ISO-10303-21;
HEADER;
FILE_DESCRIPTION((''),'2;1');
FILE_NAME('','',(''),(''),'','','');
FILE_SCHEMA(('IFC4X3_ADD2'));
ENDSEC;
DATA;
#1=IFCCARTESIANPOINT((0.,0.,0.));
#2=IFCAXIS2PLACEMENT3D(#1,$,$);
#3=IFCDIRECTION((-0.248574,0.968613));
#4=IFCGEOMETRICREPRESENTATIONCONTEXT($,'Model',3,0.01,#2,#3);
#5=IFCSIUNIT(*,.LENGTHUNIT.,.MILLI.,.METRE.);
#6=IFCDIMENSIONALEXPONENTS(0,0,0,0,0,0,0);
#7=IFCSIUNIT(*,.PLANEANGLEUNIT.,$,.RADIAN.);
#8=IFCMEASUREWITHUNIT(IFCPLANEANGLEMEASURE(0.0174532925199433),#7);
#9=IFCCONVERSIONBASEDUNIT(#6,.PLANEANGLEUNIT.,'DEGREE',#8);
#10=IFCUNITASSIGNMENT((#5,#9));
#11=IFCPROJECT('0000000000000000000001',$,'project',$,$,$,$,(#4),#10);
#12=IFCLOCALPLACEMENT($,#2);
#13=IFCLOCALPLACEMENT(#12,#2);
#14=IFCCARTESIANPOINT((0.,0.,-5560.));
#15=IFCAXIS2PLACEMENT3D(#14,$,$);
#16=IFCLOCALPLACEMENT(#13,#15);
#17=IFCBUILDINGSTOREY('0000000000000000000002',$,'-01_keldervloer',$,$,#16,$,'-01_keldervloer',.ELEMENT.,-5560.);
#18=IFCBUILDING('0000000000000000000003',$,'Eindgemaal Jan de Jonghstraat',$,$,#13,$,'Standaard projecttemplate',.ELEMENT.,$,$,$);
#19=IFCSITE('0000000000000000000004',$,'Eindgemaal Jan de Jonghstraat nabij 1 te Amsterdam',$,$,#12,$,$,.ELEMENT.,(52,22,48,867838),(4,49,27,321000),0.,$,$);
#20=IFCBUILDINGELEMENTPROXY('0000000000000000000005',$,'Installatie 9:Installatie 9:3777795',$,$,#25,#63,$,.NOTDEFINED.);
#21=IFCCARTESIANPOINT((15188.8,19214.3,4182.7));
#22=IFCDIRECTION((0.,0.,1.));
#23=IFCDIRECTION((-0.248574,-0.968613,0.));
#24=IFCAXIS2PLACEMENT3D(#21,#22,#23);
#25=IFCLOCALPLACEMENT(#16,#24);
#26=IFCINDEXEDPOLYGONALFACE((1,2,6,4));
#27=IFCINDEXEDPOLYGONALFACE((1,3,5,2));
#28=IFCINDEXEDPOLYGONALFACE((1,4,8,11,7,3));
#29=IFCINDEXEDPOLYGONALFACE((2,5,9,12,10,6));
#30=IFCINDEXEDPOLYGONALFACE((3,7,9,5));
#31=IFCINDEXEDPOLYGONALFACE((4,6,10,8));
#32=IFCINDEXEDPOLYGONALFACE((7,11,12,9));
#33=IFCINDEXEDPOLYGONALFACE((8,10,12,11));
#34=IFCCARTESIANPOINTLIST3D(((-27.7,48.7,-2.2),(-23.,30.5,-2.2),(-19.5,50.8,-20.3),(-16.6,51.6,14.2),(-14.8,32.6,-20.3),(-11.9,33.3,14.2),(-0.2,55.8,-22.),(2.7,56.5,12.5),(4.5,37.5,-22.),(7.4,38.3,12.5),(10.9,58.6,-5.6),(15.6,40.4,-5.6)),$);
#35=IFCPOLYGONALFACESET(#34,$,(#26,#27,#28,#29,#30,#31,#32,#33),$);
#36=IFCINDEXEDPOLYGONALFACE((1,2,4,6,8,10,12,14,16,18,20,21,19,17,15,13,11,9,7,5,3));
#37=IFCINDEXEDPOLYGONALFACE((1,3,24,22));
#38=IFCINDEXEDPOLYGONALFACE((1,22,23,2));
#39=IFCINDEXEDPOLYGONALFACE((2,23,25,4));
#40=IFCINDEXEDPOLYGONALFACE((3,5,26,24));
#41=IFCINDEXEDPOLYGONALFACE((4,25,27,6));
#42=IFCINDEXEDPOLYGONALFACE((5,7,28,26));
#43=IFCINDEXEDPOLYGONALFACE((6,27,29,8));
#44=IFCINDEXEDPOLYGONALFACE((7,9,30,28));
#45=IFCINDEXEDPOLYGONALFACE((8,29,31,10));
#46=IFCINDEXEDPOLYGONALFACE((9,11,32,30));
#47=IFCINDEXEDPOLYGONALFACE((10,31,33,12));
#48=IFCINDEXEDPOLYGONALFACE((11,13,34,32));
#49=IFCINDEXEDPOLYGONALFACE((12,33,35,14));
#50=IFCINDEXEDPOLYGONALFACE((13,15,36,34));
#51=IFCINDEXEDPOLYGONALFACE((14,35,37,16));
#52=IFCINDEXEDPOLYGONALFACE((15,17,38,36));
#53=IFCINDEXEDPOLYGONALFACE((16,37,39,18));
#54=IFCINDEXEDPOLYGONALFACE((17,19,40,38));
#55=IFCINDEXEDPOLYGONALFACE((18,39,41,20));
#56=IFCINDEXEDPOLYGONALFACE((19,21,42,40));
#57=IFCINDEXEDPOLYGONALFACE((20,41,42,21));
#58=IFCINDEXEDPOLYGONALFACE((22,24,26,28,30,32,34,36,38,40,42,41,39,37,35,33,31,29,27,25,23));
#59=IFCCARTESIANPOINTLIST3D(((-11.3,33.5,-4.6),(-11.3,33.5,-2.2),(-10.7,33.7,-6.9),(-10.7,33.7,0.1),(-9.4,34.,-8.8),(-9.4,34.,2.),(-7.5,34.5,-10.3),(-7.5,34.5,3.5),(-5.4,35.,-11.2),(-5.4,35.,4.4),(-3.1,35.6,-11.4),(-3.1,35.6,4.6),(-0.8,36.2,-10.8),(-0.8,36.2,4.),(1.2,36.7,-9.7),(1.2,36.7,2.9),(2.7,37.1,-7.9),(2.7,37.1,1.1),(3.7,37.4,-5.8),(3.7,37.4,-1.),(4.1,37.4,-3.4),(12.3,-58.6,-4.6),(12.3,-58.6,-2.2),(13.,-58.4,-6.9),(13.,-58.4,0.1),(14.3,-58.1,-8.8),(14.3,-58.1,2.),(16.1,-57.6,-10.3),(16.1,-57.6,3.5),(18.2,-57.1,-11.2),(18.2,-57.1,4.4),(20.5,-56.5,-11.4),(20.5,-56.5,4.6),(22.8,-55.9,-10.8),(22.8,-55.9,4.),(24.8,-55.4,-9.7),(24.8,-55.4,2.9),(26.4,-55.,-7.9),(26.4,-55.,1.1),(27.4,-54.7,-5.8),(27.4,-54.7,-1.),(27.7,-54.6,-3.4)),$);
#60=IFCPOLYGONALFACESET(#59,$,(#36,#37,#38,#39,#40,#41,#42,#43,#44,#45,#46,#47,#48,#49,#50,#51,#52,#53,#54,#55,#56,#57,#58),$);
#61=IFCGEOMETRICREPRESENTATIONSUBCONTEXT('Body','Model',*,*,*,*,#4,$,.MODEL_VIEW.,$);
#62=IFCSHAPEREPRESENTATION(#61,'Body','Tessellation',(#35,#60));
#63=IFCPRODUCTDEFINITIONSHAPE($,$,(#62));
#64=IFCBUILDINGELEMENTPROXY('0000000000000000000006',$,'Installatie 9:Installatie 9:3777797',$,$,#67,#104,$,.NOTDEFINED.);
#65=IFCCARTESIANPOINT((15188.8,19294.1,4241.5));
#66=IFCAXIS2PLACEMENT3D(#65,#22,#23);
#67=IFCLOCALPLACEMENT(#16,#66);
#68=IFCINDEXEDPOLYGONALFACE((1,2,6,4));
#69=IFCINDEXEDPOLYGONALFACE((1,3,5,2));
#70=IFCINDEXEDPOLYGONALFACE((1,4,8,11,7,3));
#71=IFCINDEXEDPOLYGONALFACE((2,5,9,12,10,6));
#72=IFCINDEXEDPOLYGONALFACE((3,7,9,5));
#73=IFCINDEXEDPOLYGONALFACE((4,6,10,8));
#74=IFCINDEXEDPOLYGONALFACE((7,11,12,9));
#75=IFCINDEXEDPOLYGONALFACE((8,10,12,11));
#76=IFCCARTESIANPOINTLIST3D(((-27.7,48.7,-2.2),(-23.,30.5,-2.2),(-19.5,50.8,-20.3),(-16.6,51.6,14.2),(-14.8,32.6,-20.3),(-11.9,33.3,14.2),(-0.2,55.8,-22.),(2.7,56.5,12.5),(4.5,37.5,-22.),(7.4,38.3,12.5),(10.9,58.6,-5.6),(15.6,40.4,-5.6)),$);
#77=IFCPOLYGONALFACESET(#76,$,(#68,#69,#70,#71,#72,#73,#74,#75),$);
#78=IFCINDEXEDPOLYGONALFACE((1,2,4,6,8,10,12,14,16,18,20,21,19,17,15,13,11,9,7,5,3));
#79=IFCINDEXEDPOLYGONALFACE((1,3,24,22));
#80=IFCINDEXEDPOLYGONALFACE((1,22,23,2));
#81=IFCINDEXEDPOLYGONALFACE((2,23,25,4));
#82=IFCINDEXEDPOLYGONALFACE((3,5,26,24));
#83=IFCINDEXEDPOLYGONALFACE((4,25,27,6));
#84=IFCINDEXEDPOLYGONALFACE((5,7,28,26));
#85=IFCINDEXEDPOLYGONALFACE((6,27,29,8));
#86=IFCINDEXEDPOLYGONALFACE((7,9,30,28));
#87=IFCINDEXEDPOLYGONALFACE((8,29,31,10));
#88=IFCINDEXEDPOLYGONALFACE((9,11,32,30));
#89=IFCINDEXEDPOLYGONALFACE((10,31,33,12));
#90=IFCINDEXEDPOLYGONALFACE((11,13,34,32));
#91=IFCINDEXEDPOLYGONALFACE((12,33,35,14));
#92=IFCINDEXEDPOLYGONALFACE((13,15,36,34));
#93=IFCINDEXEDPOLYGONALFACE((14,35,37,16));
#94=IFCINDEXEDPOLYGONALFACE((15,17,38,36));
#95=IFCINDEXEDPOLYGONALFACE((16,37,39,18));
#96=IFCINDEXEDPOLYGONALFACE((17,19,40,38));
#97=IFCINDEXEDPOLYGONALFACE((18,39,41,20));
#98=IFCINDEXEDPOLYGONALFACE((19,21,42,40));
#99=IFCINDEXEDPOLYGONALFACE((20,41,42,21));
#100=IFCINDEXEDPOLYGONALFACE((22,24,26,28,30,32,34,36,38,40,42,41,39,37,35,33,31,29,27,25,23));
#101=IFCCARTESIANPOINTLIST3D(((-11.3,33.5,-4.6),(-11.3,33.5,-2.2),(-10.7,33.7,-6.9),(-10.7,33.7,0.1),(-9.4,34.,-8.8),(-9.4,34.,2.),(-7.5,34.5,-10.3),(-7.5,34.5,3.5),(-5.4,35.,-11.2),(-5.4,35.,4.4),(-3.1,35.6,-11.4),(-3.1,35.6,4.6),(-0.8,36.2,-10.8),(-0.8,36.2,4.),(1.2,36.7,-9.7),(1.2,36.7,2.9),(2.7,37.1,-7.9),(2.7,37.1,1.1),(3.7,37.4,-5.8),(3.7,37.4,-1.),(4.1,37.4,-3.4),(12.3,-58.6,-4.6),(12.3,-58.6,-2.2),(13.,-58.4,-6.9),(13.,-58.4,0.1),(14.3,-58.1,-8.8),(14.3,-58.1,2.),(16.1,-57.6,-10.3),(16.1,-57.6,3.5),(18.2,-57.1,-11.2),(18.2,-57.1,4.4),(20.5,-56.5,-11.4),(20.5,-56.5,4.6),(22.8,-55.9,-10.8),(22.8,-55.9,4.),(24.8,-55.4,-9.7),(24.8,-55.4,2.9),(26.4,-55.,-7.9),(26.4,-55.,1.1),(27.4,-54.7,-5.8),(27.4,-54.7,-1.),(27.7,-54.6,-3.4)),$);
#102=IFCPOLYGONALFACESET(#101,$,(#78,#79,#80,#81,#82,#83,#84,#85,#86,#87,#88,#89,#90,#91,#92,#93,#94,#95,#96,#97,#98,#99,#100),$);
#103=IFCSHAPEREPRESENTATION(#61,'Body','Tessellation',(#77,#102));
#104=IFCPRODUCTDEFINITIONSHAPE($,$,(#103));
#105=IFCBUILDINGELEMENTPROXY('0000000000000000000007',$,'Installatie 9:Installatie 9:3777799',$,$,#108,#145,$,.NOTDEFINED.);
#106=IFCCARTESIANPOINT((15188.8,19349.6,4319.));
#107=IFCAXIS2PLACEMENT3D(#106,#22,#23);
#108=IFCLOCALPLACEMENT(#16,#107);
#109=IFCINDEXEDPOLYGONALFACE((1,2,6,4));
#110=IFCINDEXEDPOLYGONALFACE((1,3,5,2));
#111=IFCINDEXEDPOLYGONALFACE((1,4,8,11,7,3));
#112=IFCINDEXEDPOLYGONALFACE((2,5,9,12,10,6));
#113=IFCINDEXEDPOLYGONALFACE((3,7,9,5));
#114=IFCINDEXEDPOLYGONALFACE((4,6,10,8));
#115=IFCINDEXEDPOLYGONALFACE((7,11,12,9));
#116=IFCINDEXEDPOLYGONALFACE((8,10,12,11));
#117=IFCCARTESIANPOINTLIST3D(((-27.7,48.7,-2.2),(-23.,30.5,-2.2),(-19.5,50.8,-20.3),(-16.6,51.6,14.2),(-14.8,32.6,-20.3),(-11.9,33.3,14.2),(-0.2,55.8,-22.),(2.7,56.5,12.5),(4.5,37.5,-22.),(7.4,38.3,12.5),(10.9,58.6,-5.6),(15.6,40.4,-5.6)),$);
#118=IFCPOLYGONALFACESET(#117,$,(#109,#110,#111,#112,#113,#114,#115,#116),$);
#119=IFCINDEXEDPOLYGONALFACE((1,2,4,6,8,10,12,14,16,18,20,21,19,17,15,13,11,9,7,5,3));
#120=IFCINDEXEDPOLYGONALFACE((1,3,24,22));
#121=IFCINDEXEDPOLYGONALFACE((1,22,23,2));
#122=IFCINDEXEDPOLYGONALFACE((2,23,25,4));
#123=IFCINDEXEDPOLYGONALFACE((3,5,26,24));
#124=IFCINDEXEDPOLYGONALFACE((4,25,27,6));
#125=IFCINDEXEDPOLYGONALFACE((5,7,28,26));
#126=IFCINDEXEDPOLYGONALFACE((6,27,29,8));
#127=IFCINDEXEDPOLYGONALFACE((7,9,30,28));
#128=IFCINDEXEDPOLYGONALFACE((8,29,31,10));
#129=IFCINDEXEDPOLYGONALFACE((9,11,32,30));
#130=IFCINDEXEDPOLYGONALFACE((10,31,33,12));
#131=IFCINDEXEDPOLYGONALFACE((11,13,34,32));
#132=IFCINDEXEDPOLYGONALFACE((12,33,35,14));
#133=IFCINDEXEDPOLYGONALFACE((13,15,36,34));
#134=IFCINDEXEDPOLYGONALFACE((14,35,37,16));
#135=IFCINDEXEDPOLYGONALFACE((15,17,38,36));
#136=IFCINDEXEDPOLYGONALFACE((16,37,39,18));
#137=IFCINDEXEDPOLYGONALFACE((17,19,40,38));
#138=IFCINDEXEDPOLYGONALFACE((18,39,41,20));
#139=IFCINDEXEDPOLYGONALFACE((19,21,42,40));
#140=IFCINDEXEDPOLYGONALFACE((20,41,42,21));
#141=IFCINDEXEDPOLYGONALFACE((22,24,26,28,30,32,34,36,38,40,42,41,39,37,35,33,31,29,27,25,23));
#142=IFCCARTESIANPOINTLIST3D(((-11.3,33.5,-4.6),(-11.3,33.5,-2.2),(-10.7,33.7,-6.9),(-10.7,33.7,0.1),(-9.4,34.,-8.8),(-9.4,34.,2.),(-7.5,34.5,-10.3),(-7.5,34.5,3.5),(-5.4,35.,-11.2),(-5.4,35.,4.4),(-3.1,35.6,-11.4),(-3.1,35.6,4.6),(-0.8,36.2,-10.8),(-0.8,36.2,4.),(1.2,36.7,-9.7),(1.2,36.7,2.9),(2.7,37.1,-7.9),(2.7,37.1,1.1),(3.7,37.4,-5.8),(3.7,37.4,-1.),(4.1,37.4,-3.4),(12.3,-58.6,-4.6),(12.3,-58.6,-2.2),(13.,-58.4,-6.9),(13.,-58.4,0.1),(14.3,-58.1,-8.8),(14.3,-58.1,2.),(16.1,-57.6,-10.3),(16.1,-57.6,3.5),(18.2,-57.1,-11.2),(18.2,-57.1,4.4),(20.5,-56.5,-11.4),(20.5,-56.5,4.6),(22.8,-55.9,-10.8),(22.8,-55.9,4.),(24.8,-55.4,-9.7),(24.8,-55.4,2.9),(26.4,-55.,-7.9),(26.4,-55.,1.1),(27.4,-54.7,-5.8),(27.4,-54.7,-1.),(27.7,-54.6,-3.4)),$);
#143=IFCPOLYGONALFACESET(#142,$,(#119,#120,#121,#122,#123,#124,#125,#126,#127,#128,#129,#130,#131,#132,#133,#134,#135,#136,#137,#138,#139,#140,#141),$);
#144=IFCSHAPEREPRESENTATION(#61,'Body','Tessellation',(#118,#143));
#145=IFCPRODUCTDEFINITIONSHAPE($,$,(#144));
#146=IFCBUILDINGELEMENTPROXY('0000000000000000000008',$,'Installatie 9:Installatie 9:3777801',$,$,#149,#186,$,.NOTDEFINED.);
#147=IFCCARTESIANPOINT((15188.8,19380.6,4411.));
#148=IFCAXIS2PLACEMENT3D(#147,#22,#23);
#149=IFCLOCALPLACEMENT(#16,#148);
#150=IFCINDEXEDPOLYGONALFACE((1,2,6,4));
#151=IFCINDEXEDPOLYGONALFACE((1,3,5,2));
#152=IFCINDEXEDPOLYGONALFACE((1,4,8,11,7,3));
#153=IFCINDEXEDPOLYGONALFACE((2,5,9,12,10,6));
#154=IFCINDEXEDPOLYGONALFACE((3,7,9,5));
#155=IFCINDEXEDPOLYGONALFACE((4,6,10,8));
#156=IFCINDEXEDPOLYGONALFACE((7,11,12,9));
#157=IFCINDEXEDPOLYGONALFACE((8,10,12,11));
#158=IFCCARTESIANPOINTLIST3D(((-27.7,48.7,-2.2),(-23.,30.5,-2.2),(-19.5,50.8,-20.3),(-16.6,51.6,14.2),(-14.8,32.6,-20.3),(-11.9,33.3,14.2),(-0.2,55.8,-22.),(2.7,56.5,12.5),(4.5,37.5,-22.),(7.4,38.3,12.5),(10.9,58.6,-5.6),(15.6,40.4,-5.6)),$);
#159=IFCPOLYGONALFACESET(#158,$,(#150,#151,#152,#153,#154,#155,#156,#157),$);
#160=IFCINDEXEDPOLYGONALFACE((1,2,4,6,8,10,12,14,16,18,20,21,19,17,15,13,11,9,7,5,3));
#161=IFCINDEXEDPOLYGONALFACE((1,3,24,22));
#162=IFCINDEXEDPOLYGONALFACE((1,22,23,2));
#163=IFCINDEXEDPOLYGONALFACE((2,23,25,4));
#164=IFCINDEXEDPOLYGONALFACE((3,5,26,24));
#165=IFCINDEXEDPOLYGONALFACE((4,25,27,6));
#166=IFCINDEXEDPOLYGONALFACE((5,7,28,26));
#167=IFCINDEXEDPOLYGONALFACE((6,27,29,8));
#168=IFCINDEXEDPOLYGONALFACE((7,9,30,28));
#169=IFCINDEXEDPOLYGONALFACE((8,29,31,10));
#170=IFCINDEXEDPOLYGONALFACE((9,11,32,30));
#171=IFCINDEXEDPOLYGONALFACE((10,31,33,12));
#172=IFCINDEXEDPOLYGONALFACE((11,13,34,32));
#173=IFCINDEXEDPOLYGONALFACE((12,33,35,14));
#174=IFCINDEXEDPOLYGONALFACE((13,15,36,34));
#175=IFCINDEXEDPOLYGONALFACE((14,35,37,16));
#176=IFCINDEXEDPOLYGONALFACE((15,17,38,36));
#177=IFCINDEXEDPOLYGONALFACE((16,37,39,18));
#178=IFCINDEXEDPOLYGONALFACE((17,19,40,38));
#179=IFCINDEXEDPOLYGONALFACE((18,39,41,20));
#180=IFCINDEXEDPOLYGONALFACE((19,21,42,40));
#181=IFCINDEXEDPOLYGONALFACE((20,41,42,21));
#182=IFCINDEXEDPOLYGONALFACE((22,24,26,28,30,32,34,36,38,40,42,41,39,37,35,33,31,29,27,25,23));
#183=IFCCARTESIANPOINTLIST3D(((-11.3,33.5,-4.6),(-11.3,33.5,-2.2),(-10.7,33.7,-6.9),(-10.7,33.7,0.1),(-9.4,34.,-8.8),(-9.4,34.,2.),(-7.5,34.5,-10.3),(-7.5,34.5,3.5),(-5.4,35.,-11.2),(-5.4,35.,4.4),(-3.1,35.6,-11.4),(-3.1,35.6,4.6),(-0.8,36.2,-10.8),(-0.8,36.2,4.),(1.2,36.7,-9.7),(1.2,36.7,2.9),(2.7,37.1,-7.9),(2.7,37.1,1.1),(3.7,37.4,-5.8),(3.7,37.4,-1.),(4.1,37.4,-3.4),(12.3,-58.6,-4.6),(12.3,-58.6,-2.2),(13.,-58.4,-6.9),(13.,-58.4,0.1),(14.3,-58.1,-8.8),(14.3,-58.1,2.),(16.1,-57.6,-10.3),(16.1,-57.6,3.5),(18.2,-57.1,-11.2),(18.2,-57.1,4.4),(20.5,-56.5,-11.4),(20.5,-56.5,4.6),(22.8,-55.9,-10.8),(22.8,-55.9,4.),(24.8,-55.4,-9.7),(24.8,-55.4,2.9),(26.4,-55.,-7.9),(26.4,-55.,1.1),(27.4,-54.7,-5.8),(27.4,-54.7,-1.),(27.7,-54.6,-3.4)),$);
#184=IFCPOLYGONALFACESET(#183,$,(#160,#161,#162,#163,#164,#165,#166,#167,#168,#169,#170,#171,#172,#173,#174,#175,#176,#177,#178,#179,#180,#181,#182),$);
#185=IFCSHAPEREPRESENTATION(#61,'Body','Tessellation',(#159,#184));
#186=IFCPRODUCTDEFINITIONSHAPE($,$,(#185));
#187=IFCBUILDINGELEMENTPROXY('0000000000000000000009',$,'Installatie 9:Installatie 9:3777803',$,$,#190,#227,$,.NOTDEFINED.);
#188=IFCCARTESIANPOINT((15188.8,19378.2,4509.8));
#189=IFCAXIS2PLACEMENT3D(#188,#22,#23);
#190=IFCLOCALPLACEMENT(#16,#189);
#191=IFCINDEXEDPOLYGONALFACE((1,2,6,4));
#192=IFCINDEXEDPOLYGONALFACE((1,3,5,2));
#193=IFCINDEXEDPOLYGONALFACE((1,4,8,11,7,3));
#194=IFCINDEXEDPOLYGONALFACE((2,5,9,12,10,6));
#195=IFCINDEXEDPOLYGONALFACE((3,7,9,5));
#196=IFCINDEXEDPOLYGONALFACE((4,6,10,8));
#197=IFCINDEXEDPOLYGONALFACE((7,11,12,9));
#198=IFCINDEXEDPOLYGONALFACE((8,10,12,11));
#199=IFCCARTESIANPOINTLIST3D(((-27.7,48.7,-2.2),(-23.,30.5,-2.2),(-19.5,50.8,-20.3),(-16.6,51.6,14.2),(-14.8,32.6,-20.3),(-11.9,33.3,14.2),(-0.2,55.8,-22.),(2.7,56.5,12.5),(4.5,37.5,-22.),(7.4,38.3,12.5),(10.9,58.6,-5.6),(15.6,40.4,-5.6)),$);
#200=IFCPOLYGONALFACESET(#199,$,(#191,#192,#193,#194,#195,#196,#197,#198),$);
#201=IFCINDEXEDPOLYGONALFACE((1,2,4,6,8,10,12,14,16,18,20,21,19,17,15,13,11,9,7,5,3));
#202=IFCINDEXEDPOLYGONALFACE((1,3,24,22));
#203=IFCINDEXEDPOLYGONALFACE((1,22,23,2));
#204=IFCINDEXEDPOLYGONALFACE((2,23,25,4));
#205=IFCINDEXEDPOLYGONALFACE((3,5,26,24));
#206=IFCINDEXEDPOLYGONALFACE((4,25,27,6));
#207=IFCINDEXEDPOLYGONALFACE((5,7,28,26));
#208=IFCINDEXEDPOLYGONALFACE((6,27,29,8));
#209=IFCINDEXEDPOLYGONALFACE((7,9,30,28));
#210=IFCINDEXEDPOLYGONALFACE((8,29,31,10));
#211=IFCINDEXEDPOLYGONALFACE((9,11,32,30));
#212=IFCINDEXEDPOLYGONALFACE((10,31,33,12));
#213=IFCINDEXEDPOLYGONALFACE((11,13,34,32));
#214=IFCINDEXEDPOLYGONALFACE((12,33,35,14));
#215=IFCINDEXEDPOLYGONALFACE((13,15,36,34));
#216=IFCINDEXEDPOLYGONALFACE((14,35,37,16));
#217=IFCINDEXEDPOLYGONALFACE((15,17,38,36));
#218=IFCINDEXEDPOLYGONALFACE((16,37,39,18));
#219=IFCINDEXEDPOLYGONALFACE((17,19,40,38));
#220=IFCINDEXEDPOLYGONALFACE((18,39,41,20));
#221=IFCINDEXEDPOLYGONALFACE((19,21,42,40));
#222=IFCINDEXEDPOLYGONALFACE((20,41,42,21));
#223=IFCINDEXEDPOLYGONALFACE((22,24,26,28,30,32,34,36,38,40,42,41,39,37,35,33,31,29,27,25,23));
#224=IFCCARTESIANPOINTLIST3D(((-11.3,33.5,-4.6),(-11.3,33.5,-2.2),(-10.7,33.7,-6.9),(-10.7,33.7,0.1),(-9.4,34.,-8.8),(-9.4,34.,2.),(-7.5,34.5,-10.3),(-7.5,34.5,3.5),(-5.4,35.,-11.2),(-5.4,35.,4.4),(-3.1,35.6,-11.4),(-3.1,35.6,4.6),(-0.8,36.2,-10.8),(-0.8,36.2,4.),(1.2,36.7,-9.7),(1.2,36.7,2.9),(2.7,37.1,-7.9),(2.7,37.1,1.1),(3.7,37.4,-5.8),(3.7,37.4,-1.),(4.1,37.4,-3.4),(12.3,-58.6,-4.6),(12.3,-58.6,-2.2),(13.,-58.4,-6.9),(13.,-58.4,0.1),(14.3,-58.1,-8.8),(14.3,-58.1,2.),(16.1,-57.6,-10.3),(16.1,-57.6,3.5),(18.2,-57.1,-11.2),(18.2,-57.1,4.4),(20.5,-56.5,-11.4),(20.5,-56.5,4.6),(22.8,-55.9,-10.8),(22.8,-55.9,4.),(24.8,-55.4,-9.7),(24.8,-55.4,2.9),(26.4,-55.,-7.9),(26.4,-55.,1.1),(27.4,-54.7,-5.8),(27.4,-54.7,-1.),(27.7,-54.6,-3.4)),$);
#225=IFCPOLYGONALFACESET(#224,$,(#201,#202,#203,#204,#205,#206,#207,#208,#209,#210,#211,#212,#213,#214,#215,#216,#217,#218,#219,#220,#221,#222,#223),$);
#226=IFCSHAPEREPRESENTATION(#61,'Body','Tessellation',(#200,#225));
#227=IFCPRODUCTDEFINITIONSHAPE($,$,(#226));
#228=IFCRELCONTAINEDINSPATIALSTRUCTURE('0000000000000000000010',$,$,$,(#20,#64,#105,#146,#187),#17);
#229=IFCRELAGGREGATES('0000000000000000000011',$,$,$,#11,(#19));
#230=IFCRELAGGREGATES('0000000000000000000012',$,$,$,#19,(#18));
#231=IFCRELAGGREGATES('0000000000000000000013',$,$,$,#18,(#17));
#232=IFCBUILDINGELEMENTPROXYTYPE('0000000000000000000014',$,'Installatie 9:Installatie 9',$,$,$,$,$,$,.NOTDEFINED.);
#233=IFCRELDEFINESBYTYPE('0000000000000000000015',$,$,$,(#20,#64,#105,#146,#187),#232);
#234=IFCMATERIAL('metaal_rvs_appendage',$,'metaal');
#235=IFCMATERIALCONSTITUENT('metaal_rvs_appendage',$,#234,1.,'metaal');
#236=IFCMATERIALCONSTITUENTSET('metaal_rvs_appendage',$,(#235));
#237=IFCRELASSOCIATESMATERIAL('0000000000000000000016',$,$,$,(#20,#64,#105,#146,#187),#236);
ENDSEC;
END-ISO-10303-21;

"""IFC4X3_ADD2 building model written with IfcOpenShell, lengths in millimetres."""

from ifc_helpers import new_model, entity, si_unit, converted_unit, direction, frame, frame_2d, origin, place, context, subcontext, project, spatial, polyline, circle, outline, extrude, source, transform, mapped, material, constituent, constituent_set, type_object, type_shapes, element, save


model = new_model("IFC4X3_ADD2")

# Units and contexts
model_context = context("Model", 3, precision=0.01, world=origin(), true_north=direction((-0.248574, 0.968613)))
body_context = subcontext(model_context, "Body", "Model", "MODEL_VIEW")
ifc_project = project(units=[si_unit("LENGTHUNIT", "METRE", prefix="MILLI"), converted_unit("PLANEANGLEUNIT", "DEGREE", entity("IfcPlaneAngleMeasure", 0.0174532925199433), si_unit("PLANEANGLEUNIT", "RADIAN"), dimensions=[0, 0, 0, 0, 0, 0, 0])], contexts=[model_context])

# Site, building, storey
site_placement = place(None, origin())
site = spatial("IfcSite", under=ifc_project, at=site_placement, Name="Eindgemaal Jan de Jonghstraat nabij 1 te Amsterdam", CompositionType="ELEMENT", RefLatitude=(52, 22, 48, 867838), RefLongitude=(4, 49, 27, 321000), RefElevation=0.0)
building_placement = place(site_placement, origin())
building = spatial("IfcBuilding", under=site, at=building_placement, Name="Eindgemaal Jan de Jonghstraat", LongName="Standaard projecttemplate", CompositionType="ELEMENT")
storey_placement = place(building_placement, frame((0.0, 0.0, -5560.0)))
storey = spatial("IfcBuildingStorey", under=building, at=storey_placement, Name="-01_keldervloer", LongName="-01_keldervloer", CompositionType="ELEMENT", Elevation=-5560.0)

# Building element proxies
ifc_material_1 = material(Name="metaal_rvs_appendage", Category="metaal")
ifc_constituent_1 = constituent(ifc_material_1, Name="metaal_rvs_appendage", Category="metaal", fraction=1.0)
ifc_constituent_set_1 = constituent_set(constituents=[ifc_constituent_1], Name="metaal_rvs_appendage")
building_element_proxy_type = type_object("IfcBuildingElementProxyType", Name="Installatie 9:Installatie 9", PredefinedType="NOTDEFINED")
shared_shape_1 = source(origin(), body_context, "Body", "SweptSolid", [
    extrude(outline(polyline([(-10.0, -17.3), (10.0, -17.3), (20.0, 0.0), (10.0, 17.3), (-10.0, 17.3), (-20.0, 0.0), (-10.0, -17.3)])), frame((-3.7, 35.4, -3.9), z_axis=(-0.248574, 0.968613, 0.0), x_axis=(-0.555573, -0.142576, -0.819152)), (0.0, 0.0, 1.0), 18.8),
    extrude(circle(Radius=8.0, at=frame_2d((0.0, 0.0), x_axis=(1.0, 0.0))), frame((20.0, -56.6, -3.4), z_axis=(-0.248574, 0.968613, 0.0), x_axis=(0.968613, 0.248574, 0.0)), (0.0, 0.0, 1.0), 95.1),
])
type_shapes(building_element_proxy_type, [shared_shape_1])
for number, where, z_axis, x_axis, name in (
    (1, (15188.8, 19214.3, 4182.7), (0.0, 0.0, 1.0), (-0.248574, -0.968613, 0.0), "Installatie 9:Installatie 9:3777795"),
    (2, (15188.8, 19294.1, 4241.5), (0.0, 0.0, 1.0), (-0.248574, -0.968613, 0.0), "Installatie 9:Installatie 9:3777797"),
    (3, (15188.8, 19349.6, 4319.0), (0.0, 0.0, 1.0), (-0.248574, -0.968613, 0.0), "Installatie 9:Installatie 9:3777799"),
    (4, (15188.8, 19380.6, 4411.0), (0.0, 0.0, 1.0), (-0.248574, -0.968613, 0.0), "Installatie 9:Installatie 9:3777801"),
    (5, (15188.8, 19378.2, 4509.8), (0.0, 0.0, 1.0), (-0.248574, -0.968613, 0.0), "Installatie 9:Installatie 9:3777803"),
):
    element("IfcBuildingElementProxy", number, at=place(storey_placement, frame(where, z_axis=z_axis, x_axis=x_axis)), inside=storey, type_object=building_element_proxy_type, material=ifc_constituent_set_1, Name=name, PredefinedType="NOTDEFINED", context=body_context, shape_type="MappedRepresentation", body=[
        mapped(shared_shape_1, transform((0.0, 0.0, 0.0), scale=1.0)),
    ])

save(model, "model.ifc")
